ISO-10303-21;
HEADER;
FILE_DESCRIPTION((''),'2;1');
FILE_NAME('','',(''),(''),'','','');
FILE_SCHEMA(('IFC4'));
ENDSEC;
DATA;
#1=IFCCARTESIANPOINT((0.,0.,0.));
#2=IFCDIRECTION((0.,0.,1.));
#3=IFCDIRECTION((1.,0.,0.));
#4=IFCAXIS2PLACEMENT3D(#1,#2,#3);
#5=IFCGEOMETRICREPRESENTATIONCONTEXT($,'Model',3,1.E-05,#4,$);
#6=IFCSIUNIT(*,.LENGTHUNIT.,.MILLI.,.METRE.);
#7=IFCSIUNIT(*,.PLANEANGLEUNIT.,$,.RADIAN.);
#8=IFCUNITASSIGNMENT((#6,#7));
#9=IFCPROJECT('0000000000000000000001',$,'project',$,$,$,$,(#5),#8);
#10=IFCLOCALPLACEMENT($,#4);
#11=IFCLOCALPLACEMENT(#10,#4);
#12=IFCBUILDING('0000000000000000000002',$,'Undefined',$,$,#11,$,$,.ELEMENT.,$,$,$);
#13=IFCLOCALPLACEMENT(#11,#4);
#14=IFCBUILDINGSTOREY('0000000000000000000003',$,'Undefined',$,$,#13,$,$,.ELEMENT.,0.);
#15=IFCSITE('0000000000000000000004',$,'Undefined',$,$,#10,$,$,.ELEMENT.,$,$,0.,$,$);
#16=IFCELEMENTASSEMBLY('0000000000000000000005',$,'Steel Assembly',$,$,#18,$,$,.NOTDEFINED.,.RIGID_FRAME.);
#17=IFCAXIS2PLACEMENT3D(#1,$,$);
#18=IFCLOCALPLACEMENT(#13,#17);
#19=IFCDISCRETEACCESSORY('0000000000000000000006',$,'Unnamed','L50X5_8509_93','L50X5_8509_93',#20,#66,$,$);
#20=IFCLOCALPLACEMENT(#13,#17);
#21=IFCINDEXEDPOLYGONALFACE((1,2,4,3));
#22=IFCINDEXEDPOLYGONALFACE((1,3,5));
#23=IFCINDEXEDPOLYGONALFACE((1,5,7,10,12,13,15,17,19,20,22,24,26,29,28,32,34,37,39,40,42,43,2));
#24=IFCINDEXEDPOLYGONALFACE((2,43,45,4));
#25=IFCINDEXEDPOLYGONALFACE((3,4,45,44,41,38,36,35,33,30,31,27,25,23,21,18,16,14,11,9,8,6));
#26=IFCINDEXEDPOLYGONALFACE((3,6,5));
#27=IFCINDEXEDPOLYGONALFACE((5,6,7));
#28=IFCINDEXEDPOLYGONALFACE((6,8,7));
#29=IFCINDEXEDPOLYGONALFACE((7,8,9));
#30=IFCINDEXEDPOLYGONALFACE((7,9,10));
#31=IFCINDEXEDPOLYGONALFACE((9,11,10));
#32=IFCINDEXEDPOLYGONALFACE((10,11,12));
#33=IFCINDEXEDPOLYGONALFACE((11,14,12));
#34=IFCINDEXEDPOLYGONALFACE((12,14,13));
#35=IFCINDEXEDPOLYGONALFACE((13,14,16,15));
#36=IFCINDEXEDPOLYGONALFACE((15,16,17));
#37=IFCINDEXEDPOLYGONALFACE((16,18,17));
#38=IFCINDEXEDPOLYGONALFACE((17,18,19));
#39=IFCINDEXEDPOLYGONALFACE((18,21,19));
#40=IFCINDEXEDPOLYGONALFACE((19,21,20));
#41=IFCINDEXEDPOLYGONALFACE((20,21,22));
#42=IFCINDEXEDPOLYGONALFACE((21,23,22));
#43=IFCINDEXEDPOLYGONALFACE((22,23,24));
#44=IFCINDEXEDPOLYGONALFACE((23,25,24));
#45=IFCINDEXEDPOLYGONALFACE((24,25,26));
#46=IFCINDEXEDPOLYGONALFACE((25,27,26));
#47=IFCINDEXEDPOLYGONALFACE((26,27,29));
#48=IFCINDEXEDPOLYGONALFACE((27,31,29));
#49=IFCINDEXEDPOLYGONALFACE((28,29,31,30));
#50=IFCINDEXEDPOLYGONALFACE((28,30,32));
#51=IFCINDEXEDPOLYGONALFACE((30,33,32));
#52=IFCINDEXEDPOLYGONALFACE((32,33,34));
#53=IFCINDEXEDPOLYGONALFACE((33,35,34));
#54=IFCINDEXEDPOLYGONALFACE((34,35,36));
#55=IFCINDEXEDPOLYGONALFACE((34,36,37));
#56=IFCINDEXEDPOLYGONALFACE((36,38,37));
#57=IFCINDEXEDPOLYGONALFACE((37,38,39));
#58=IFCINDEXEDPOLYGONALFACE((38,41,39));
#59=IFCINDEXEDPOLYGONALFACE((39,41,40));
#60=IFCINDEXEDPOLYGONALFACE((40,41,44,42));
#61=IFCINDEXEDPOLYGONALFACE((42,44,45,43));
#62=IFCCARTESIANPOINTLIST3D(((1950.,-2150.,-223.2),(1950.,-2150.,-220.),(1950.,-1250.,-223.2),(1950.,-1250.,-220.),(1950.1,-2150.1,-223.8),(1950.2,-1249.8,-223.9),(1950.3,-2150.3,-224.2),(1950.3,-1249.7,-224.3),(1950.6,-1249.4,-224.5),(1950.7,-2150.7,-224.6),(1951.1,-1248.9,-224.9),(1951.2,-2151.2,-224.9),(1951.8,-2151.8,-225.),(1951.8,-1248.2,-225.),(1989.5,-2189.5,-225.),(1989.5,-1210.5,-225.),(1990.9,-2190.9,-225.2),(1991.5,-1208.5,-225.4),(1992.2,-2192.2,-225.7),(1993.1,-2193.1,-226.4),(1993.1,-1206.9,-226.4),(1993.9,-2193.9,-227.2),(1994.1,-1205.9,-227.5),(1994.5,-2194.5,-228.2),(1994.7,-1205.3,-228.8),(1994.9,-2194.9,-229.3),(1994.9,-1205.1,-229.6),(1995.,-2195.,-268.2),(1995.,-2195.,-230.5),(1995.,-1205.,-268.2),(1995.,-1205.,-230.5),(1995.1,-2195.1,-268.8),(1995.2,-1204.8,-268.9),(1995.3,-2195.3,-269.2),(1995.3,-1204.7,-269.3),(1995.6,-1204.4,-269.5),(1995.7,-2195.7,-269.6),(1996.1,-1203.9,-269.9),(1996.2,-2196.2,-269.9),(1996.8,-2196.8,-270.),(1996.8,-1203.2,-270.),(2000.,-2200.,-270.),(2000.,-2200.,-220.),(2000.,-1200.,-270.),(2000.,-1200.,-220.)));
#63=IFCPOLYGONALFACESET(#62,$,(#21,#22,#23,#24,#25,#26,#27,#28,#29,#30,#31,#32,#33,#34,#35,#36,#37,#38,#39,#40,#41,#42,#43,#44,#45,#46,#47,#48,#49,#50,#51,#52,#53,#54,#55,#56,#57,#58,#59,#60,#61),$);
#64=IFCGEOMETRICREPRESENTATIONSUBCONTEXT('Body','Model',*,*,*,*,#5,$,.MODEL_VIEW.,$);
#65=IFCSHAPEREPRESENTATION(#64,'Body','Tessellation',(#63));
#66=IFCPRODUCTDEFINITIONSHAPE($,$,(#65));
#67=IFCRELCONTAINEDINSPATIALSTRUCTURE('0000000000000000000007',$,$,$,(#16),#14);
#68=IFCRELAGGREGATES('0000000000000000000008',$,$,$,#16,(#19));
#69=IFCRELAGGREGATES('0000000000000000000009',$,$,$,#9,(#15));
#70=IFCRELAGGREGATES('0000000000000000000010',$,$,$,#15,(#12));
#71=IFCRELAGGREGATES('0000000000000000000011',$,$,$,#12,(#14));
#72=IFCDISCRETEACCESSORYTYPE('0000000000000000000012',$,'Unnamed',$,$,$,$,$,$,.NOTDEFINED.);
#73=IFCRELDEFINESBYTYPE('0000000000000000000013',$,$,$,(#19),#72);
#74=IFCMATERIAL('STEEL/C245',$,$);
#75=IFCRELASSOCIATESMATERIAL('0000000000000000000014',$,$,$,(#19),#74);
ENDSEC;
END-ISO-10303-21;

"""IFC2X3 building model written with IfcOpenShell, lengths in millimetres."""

from ifc_helpers import new_model, si_unit, frame, origin_with_axes, origin_2d_with_axis, place, context, subcontext, project, spatial, l_section, extrude, clip, halfspace, material, type_object, element, aggregate, save


model = new_model("IFC2X3")

# Units and contexts
model_context = context("Model", 3, precision=1e-05, world=origin_with_axes())
body_context = subcontext(model_context, "Body", "Model", "MODEL_VIEW")
ifc_project = project(units=[si_unit("LENGTHUNIT", "METRE", prefix="MILLI"), si_unit("PLANEANGLEUNIT", "RADIAN")], contexts=[model_context])

# Site, building, storey
site_placement = place(None, origin_with_axes())
site = spatial("IfcSite", under=ifc_project, at=site_placement, Name="Undefined", CompositionType="ELEMENT", RefElevation=0.0)
building_placement = place(site_placement, origin_with_axes())
building = spatial("IfcBuilding", under=site, at=building_placement, Name="Undefined", CompositionType="ELEMENT")
storey_placement = place(building_placement, origin_with_axes())
storey = spatial("IfcBuildingStorey", under=building, at=storey_placement, Name="Undefined", CompositionType="ELEMENT", Elevation=0.0)

# Shared definitions
ifc_material_1 = material(Name="STEEL/C245")

# Element assembly
assembly_1_placement = place(storey_placement, origin_with_axes())
assembly_1 = element("IfcElementAssembly", 1, at=assembly_1_placement, inside=storey, Name="Steel Assembly", AssemblyPlace="NOTDEFINED", PredefinedType="RIGID_FRAME")

# Discrete accessory
discrete_accessory_type_1 = type_object("IfcDiscreteAccessoryType", Name="Unnamed")
discrete_accessory_1_placement = place(assembly_1_placement, frame((1975.0, -1200.0, -245.0), z_axis=(-1.0, 0.0, 0.0), x_axis=(0.0, -1.0, 0.0)))
discrete_accessory_1 = element("IfcDiscreteAccessory", 2, at=discrete_accessory_1_placement, type_object=discrete_accessory_type_1, material=ifc_material_1, Name="Unnamed", Description="L50X5_8509_93", ObjectType="L50X5_8509_93", context=body_context, shape_type="Clipping", body=[
    clip(clip(extrude(l_section(Depth=50.0, Width=50.0, Thickness=5.0, FilletRadius=5.5, EdgeRadius=1.8, at=origin_2d_with_axis()), frame((1000.0, 0.0, 0.0), z_axis=(-1.0, 0.0, 0.0), x_axis=(0.0, -1.0, 0.0)), (0.0, 0.0, 1.0), 1000.0), halfspace(frame((0.0, -25.0, -25.0), z_axis=(-0.707107, 0.0, 0.707107), x_axis=(0.0, 1.0, 0.0)), False)), halfspace(frame((1000.0, 25.0, -25.0), z_axis=(0.707107, 0.0, 0.707107), x_axis=(0.0, -1.0, 0.0)), False)),
])
aggregate(assembly_1, [discrete_accessory_1])

save(model, "model.ifc")
